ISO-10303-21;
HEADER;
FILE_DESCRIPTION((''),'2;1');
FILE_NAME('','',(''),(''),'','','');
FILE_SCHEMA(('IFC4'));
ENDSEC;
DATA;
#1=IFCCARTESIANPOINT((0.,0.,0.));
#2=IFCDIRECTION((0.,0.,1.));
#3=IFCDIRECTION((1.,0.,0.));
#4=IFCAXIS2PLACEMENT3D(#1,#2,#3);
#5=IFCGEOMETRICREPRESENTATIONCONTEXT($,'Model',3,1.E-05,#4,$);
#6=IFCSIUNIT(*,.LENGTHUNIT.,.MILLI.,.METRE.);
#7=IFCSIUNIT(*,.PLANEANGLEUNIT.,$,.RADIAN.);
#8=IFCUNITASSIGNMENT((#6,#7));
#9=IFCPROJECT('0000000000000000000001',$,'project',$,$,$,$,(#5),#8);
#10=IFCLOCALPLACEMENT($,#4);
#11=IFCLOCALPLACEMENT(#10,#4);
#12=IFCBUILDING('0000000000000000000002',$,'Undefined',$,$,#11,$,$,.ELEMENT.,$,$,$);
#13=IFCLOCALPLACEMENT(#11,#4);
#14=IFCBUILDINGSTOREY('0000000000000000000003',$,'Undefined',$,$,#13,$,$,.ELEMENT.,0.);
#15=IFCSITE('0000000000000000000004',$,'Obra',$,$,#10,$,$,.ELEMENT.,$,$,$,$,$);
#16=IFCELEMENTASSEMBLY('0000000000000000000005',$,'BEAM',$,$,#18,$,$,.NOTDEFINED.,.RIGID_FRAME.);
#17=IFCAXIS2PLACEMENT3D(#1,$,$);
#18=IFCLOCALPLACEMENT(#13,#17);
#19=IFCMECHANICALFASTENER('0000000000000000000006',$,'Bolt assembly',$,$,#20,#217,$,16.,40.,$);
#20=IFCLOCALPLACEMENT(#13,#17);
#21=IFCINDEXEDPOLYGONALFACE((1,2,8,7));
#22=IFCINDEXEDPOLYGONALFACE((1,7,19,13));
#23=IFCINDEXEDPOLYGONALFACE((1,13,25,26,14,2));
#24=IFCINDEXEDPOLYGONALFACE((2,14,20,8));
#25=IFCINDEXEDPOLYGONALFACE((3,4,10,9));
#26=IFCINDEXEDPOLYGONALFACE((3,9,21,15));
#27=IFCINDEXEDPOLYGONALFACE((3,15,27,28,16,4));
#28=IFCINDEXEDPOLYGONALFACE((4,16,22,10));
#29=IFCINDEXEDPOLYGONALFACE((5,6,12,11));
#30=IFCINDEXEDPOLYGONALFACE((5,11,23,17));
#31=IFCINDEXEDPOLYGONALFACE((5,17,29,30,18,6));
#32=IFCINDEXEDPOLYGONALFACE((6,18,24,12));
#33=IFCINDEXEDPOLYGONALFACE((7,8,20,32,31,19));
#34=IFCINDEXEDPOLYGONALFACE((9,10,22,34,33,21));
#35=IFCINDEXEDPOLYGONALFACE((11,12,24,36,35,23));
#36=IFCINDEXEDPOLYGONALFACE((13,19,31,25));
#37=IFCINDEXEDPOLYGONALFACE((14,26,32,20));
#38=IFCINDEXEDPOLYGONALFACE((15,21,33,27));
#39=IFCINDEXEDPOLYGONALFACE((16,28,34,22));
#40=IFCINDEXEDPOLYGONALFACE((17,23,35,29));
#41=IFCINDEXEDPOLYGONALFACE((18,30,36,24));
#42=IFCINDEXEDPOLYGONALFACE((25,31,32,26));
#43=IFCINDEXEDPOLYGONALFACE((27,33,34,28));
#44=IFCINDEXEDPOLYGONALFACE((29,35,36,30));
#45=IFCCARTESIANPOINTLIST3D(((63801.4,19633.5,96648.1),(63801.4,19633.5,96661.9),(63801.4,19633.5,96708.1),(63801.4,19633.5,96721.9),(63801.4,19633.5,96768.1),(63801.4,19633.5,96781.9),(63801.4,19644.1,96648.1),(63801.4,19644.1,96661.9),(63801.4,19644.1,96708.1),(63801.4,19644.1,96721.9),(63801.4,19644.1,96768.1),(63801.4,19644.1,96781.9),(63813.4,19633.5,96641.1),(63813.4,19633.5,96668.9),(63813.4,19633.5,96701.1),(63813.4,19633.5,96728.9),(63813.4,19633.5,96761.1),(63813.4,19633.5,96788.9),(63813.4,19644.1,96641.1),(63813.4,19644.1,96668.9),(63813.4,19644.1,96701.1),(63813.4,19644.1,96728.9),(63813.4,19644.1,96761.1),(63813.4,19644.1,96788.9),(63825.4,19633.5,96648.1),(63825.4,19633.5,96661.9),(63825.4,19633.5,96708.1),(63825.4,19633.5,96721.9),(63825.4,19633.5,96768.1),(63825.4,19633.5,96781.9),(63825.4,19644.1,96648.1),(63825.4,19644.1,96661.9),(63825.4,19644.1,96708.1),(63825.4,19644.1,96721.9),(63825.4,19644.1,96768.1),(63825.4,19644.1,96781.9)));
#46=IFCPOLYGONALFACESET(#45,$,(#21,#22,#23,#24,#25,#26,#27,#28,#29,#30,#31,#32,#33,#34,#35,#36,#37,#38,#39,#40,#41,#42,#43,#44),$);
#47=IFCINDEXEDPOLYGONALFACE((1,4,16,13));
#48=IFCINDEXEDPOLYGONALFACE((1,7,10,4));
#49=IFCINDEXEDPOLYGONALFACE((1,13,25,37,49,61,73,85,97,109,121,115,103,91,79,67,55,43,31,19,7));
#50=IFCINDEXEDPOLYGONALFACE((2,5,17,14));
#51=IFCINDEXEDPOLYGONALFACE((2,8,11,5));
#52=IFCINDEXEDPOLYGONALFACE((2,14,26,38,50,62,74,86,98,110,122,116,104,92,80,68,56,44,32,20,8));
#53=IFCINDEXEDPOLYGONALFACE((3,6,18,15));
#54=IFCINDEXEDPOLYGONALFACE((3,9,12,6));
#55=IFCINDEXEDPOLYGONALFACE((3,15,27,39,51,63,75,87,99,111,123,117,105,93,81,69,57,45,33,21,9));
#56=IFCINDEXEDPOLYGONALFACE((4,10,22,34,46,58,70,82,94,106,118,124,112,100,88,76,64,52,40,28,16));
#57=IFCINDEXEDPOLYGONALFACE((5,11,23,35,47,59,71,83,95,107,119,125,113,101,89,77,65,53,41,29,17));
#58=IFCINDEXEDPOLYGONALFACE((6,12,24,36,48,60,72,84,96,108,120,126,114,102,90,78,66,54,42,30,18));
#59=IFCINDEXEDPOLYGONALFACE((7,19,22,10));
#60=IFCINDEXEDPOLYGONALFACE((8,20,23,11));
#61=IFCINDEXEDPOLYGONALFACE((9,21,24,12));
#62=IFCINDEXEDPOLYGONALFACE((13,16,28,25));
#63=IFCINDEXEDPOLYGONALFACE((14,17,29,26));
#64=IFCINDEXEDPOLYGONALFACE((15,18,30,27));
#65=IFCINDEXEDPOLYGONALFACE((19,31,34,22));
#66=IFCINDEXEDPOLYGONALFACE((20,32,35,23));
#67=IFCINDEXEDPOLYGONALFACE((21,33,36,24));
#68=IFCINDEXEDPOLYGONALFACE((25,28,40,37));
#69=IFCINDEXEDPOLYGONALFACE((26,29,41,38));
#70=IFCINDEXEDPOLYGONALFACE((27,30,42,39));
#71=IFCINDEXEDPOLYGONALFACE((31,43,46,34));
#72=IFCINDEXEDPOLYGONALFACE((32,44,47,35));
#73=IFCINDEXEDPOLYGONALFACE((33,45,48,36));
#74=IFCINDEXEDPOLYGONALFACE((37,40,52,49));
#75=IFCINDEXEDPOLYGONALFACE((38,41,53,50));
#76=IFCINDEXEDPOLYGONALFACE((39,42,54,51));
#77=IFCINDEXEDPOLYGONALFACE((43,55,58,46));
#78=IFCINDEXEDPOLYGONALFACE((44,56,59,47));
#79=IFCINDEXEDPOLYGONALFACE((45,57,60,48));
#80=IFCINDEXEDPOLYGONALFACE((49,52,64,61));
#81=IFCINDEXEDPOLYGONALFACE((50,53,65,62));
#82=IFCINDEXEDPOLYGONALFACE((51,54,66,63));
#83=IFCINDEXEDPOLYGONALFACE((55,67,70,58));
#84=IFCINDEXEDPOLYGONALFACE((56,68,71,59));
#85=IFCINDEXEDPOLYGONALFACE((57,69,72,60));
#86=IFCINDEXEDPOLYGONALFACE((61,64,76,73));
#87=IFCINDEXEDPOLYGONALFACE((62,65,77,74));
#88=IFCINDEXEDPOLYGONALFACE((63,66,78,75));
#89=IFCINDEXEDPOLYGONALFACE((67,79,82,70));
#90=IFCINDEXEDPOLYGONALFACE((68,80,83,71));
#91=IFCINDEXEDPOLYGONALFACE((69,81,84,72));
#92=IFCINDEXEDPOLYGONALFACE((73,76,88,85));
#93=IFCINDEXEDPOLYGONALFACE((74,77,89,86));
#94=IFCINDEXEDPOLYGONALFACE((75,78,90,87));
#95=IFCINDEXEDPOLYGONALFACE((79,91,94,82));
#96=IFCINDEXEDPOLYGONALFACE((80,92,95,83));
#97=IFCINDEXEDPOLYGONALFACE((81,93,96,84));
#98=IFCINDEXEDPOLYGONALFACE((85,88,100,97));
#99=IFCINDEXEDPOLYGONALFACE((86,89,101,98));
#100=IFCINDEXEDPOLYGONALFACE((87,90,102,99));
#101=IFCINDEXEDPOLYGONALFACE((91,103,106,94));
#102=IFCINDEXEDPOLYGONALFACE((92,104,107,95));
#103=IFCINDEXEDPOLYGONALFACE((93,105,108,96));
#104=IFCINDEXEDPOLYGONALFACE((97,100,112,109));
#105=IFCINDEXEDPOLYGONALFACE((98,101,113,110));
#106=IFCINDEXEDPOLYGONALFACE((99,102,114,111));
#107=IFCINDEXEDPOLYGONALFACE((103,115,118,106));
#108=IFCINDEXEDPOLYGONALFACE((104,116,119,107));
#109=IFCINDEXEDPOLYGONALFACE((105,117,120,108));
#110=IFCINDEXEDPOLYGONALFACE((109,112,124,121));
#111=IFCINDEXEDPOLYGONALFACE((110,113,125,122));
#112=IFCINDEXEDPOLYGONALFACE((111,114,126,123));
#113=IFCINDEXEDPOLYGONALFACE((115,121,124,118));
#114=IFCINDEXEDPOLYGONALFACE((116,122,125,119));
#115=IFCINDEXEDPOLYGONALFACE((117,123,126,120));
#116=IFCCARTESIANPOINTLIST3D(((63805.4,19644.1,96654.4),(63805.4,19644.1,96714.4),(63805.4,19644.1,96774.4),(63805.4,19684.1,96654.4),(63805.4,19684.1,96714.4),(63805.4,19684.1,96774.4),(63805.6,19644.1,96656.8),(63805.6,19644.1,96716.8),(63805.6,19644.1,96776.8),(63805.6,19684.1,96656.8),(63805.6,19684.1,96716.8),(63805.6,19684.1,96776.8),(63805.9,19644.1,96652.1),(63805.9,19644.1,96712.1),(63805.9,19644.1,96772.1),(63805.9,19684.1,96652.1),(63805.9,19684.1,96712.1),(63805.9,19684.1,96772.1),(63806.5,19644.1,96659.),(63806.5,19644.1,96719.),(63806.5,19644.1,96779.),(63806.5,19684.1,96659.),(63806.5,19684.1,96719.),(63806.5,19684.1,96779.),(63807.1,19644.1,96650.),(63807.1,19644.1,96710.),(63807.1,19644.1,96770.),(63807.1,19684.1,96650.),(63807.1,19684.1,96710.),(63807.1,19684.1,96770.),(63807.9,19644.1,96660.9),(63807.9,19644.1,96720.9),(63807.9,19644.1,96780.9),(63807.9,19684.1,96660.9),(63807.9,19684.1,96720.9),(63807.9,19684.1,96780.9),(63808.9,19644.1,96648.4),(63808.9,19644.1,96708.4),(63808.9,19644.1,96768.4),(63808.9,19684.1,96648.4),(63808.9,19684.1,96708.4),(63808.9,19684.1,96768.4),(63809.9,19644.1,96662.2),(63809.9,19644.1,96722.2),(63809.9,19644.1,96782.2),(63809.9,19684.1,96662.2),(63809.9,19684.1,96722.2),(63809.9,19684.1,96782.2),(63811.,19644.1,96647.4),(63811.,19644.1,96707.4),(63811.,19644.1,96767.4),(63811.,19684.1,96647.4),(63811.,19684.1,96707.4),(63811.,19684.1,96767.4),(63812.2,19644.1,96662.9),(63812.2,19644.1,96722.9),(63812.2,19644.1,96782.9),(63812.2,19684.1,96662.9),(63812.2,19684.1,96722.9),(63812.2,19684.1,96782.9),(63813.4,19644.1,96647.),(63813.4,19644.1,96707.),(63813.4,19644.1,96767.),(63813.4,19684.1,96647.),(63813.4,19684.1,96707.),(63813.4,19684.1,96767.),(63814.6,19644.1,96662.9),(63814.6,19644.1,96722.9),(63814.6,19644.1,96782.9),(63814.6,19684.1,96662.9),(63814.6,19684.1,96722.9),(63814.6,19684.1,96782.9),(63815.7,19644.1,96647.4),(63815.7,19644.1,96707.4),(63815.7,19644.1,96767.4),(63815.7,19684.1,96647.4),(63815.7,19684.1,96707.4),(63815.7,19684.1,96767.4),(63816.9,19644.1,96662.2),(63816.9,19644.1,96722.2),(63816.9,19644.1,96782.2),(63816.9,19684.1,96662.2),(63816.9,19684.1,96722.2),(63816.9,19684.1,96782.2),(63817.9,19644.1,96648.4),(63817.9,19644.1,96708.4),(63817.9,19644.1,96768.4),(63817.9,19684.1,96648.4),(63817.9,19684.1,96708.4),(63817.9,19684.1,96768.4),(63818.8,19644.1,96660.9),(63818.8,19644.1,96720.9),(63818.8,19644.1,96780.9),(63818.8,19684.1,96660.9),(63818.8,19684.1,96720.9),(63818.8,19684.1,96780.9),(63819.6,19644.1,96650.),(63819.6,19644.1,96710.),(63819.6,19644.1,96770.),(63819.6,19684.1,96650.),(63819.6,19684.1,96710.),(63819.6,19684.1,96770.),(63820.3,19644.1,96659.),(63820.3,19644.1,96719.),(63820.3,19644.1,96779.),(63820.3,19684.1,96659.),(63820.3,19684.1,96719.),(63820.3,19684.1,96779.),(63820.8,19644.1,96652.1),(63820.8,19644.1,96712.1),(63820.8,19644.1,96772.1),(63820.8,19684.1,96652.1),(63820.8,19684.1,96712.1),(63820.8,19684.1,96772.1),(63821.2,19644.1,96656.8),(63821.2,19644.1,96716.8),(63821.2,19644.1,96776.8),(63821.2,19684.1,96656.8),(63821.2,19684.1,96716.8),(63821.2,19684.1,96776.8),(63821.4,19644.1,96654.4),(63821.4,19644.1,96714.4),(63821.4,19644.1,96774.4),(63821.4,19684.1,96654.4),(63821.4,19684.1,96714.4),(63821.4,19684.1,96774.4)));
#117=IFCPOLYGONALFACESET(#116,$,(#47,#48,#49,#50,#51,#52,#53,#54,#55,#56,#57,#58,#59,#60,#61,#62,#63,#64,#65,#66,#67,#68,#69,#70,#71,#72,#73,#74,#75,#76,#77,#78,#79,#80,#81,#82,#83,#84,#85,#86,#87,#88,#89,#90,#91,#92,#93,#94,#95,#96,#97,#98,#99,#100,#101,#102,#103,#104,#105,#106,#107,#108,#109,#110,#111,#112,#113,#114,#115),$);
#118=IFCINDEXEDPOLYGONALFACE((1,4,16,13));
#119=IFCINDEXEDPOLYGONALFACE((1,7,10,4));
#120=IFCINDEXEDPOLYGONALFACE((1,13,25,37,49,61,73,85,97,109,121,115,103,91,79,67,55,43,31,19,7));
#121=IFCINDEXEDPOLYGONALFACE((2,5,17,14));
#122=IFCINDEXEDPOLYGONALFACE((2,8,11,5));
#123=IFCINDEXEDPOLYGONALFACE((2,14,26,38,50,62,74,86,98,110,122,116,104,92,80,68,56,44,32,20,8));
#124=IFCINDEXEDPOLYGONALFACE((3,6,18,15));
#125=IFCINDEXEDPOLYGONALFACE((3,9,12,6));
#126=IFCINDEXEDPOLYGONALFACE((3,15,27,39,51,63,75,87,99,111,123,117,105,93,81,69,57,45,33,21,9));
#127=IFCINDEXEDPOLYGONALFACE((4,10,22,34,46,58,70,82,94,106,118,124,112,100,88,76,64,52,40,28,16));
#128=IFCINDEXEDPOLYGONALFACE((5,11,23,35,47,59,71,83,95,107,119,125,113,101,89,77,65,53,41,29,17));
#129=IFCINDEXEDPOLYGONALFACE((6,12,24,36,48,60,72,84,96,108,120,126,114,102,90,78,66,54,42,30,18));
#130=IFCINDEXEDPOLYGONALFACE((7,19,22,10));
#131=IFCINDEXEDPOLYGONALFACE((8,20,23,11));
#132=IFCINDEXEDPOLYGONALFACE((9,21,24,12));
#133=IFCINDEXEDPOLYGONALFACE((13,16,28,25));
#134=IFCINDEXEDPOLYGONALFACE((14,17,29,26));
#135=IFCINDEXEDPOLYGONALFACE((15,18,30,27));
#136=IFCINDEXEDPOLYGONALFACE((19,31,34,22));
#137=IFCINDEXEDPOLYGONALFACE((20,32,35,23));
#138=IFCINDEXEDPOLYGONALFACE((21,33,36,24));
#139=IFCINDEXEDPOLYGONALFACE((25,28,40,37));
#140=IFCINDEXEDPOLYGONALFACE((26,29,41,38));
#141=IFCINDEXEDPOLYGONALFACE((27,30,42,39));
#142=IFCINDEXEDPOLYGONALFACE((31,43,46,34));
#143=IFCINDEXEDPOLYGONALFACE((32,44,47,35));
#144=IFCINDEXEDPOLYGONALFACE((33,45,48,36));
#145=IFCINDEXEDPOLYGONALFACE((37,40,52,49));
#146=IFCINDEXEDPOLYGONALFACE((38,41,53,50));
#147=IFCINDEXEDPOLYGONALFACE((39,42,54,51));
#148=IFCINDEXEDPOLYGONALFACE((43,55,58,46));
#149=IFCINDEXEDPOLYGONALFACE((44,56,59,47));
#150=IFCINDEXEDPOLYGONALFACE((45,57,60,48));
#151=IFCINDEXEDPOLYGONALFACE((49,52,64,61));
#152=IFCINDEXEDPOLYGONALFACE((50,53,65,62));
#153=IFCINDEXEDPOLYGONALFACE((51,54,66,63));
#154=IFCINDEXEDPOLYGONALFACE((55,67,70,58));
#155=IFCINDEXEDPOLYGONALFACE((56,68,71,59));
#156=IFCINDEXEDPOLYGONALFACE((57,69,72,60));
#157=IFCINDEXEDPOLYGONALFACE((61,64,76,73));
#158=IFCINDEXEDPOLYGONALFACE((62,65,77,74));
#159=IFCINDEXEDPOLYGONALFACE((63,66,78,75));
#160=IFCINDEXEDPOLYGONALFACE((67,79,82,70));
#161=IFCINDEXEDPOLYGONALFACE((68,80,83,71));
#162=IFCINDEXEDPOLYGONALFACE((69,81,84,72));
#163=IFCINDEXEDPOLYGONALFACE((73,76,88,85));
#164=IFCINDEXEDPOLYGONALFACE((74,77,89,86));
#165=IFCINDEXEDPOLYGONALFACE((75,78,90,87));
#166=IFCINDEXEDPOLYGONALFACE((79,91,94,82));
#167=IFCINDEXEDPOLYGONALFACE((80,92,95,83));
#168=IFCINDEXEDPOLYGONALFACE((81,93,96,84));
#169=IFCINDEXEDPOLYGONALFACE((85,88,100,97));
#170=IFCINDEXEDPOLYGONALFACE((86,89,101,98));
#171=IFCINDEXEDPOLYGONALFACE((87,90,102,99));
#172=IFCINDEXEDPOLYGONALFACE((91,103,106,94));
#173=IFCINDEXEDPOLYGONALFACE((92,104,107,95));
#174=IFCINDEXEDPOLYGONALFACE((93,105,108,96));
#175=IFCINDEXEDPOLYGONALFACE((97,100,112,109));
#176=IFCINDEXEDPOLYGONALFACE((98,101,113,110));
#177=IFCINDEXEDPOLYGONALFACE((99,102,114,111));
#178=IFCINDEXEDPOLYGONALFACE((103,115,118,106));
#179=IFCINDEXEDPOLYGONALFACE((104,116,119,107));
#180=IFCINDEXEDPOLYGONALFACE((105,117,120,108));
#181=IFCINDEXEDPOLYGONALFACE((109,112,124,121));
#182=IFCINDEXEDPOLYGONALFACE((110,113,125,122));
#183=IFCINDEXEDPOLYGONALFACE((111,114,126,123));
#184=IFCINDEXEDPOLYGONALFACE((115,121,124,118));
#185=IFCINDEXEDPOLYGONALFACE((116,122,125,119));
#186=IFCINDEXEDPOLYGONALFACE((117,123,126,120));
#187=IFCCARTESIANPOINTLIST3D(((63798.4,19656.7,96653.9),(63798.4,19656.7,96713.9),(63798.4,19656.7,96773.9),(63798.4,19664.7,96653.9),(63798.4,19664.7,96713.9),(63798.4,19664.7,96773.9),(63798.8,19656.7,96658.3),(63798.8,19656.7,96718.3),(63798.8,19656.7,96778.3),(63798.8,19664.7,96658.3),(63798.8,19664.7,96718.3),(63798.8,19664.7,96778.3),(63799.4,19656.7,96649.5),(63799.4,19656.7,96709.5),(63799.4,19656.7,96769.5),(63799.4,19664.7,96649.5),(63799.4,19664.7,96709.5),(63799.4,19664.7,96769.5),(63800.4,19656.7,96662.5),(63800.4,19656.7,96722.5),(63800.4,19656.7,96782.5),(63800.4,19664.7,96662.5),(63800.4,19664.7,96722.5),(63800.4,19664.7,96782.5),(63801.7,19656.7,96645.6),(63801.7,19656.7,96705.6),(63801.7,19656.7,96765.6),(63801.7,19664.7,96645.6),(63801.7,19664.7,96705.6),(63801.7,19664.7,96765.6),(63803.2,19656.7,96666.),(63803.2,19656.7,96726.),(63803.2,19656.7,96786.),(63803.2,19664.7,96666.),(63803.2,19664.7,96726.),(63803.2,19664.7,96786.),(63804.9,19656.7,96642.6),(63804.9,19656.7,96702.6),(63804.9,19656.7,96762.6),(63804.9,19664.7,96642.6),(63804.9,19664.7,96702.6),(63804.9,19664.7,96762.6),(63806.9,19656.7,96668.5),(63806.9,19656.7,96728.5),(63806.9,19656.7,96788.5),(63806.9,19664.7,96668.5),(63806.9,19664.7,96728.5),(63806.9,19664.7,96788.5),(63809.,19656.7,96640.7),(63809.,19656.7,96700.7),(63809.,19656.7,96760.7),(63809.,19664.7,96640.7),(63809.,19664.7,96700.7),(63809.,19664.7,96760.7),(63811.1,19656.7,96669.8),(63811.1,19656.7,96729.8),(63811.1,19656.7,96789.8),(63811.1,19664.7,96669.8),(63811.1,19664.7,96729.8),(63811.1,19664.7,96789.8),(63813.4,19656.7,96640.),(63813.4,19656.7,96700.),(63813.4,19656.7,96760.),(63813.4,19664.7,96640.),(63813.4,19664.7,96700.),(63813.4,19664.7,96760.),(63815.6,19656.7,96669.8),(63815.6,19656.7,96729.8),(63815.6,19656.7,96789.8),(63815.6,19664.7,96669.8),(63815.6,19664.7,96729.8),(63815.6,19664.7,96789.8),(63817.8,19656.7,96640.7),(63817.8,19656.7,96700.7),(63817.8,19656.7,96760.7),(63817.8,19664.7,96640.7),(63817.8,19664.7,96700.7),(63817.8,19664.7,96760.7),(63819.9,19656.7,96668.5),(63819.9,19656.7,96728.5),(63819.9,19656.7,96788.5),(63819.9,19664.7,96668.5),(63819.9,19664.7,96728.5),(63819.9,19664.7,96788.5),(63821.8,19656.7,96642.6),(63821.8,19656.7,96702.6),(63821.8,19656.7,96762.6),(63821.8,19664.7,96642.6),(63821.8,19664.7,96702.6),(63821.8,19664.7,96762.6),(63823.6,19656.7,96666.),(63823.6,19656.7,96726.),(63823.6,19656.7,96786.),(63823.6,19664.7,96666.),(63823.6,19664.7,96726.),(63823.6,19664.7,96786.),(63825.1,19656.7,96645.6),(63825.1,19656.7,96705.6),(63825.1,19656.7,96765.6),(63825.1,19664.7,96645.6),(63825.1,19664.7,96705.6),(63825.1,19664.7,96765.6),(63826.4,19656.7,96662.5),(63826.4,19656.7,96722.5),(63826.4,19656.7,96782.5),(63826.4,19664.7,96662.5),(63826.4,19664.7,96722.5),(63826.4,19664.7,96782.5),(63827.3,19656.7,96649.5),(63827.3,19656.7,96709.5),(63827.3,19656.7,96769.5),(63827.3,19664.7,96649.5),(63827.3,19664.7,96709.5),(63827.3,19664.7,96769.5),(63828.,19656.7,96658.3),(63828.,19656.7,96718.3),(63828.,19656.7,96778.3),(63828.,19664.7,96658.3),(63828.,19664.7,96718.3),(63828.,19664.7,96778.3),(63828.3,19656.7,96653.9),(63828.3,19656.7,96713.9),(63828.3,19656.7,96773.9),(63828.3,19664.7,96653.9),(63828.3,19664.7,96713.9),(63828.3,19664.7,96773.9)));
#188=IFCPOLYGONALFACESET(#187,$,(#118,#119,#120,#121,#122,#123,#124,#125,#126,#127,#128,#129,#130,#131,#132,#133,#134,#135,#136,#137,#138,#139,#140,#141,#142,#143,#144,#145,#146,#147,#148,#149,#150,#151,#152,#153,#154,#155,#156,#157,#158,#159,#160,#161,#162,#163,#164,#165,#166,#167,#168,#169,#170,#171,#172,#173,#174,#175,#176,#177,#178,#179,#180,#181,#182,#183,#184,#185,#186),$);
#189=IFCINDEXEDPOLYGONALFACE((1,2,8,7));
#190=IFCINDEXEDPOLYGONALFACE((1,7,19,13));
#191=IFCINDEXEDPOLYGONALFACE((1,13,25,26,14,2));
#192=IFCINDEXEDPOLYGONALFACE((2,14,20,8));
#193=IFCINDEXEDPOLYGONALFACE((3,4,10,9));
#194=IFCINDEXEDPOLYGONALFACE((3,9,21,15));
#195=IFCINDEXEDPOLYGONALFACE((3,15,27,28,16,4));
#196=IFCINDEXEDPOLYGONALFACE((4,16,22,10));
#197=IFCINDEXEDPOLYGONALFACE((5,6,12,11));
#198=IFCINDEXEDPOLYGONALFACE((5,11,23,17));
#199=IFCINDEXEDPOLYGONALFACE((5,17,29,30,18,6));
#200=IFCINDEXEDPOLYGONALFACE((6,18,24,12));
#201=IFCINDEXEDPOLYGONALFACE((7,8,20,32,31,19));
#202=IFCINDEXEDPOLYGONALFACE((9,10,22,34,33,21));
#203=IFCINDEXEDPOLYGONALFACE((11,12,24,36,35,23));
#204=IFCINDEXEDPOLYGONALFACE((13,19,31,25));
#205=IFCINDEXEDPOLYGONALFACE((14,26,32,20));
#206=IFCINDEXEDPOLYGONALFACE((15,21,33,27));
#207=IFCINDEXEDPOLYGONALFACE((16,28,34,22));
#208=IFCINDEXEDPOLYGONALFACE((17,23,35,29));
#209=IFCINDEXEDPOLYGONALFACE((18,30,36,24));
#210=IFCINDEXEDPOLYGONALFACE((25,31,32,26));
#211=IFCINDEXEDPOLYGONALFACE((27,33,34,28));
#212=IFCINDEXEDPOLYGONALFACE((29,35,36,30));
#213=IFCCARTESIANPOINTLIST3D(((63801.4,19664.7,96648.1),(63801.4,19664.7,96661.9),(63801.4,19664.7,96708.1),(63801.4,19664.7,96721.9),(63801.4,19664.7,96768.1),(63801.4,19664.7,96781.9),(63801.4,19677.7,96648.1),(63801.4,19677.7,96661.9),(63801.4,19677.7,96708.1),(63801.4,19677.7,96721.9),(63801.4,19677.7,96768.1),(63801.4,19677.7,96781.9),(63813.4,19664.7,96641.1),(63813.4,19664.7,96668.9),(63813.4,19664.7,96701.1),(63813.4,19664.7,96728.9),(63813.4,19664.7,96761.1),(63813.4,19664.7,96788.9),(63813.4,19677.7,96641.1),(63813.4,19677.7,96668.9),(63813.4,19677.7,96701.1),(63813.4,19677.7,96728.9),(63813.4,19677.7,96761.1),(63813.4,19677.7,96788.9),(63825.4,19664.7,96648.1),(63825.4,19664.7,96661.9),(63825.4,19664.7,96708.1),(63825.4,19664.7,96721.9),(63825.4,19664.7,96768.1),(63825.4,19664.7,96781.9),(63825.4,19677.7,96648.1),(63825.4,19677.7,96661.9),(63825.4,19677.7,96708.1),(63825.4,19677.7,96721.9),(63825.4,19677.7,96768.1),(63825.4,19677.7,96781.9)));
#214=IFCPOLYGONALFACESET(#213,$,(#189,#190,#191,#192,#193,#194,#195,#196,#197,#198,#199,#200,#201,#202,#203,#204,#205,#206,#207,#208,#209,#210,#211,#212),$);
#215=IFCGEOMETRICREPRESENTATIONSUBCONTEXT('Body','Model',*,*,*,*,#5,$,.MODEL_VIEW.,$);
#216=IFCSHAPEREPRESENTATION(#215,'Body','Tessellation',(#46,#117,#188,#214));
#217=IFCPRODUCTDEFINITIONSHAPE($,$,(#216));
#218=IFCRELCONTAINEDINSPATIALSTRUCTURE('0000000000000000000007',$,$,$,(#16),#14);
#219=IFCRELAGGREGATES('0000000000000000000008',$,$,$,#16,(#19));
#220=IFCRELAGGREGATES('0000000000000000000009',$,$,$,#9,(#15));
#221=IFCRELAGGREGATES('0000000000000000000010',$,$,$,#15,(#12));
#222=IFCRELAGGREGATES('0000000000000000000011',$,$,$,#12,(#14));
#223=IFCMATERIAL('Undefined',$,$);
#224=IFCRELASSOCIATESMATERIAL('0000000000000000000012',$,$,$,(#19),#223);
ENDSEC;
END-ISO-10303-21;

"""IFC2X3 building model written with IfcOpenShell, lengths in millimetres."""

from ifc_helpers import new_model, si_unit, frame, origin_with_axes, origin_2d_with_axis, place, context, subcontext, project, spatial, polyline, circle, outline, extrude, source, transform, mapped, material, element, aggregate, save


model = new_model("IFC2X3")

# Units and contexts
model_context = context("Model", 3, precision=1e-05, world=origin_with_axes())
body_context = subcontext(model_context, "Body", "Model", "MODEL_VIEW")
ifc_project = project(units=[si_unit("LENGTHUNIT", "METRE", prefix="MILLI"), si_unit("PLANEANGLEUNIT", "RADIAN")], contexts=[model_context])

# Site, building, storey
site_placement = place(None, origin_with_axes())
site = spatial("IfcSite", under=ifc_project, at=site_placement, Name="Obra", CompositionType="ELEMENT")
building_placement = place(site_placement, origin_with_axes())
building = spatial("IfcBuilding", under=site, at=building_placement, Name="Undefined", CompositionType="ELEMENT")
storey_placement = place(building_placement, origin_with_axes())
storey = spatial("IfcBuildingStorey", under=building, at=storey_placement, Name="Undefined", CompositionType="ELEMENT", Elevation=0.0)

# Shared definitions
ifc_material_1 = material(Name="Undefined")

# Element assembly, mechanical fastener
shared_shape_1 = source(origin_with_axes(), body_context, "Body", "SweptSolid", [
    extrude(outline(polyline([(13.9, 0.0), (6.9, 12.0), (-6.9, 12.0), (-13.9, 0.0), (-6.9, -12.0), (6.9, -12.0), (13.9, 0.0)])), frame((0.0, -19.9, 0.0), z_axis=(0.0, 1.0, 0.0), x_axis=(1.0, 0.0, 0.0)), (0.0, 0.0, 1.0), 10.6),
    extrude(circle(Radius=8.0, at=origin_2d_with_axis()), frame((0.0, -9.3, 0.0), z_axis=(0.0, 1.0, 0.0), x_axis=(1.0, 0.0, 0.0)), (0.0, 0.0, 1.0), 40.0),
    extrude(circle(Radius=15.0, at=origin_2d_with_axis()), frame((0.0, 3.3, 0.0), z_axis=(0.0, 1.0, 0.0), x_axis=(1.0, 0.0, 0.0)), (0.0, 0.0, 1.0), 8.0),
    extrude(outline(polyline([(13.9, 0.0), (6.9, 12.0), (-6.9, 12.0), (-13.9, 0.0), (-6.9, -12.0), (6.9, -12.0), (13.9, 0.0)])), frame((0.0, 11.3, 0.0), z_axis=(0.0, 1.0, 0.0), x_axis=(1.0, 0.0, 0.0)), (0.0, 0.0, 1.0), 13.0),
])
assembly_1_placement = place(storey_placement, origin_with_axes())
assembly_1 = element("IfcElementAssembly", 1, at=assembly_1_placement, inside=storey, Name="BEAM", AssemblyPlace="NOTDEFINED", PredefinedType="RIGID_FRAME")
mechanical_fastener_1_placement = place(assembly_1_placement, frame((63763.4, 19653.4, 96850.0), z_axis=(1.0, 0.0, 0.0), x_axis=(0.0, 0.0, -1.0)))
mechanical_fastener_1 = element("IfcMechanicalFastener", 2, at=mechanical_fastener_1_placement, material=ifc_material_1, Name="Bolt assembly", NominalDiameter=16.0, NominalLength=40.0, context=body_context, shape_type="MappedRepresentation", body=[
    mapped(shared_shape_1, transform((75.0, 0.0, 50.0))),
    mapped(shared_shape_1, transform((135.0, 0.0, 50.0))),
    mapped(shared_shape_1, transform((195.0, 0.0, 50.0))),
])
aggregate(assembly_1, [mechanical_fastener_1])

save(model, "model.ifc")
